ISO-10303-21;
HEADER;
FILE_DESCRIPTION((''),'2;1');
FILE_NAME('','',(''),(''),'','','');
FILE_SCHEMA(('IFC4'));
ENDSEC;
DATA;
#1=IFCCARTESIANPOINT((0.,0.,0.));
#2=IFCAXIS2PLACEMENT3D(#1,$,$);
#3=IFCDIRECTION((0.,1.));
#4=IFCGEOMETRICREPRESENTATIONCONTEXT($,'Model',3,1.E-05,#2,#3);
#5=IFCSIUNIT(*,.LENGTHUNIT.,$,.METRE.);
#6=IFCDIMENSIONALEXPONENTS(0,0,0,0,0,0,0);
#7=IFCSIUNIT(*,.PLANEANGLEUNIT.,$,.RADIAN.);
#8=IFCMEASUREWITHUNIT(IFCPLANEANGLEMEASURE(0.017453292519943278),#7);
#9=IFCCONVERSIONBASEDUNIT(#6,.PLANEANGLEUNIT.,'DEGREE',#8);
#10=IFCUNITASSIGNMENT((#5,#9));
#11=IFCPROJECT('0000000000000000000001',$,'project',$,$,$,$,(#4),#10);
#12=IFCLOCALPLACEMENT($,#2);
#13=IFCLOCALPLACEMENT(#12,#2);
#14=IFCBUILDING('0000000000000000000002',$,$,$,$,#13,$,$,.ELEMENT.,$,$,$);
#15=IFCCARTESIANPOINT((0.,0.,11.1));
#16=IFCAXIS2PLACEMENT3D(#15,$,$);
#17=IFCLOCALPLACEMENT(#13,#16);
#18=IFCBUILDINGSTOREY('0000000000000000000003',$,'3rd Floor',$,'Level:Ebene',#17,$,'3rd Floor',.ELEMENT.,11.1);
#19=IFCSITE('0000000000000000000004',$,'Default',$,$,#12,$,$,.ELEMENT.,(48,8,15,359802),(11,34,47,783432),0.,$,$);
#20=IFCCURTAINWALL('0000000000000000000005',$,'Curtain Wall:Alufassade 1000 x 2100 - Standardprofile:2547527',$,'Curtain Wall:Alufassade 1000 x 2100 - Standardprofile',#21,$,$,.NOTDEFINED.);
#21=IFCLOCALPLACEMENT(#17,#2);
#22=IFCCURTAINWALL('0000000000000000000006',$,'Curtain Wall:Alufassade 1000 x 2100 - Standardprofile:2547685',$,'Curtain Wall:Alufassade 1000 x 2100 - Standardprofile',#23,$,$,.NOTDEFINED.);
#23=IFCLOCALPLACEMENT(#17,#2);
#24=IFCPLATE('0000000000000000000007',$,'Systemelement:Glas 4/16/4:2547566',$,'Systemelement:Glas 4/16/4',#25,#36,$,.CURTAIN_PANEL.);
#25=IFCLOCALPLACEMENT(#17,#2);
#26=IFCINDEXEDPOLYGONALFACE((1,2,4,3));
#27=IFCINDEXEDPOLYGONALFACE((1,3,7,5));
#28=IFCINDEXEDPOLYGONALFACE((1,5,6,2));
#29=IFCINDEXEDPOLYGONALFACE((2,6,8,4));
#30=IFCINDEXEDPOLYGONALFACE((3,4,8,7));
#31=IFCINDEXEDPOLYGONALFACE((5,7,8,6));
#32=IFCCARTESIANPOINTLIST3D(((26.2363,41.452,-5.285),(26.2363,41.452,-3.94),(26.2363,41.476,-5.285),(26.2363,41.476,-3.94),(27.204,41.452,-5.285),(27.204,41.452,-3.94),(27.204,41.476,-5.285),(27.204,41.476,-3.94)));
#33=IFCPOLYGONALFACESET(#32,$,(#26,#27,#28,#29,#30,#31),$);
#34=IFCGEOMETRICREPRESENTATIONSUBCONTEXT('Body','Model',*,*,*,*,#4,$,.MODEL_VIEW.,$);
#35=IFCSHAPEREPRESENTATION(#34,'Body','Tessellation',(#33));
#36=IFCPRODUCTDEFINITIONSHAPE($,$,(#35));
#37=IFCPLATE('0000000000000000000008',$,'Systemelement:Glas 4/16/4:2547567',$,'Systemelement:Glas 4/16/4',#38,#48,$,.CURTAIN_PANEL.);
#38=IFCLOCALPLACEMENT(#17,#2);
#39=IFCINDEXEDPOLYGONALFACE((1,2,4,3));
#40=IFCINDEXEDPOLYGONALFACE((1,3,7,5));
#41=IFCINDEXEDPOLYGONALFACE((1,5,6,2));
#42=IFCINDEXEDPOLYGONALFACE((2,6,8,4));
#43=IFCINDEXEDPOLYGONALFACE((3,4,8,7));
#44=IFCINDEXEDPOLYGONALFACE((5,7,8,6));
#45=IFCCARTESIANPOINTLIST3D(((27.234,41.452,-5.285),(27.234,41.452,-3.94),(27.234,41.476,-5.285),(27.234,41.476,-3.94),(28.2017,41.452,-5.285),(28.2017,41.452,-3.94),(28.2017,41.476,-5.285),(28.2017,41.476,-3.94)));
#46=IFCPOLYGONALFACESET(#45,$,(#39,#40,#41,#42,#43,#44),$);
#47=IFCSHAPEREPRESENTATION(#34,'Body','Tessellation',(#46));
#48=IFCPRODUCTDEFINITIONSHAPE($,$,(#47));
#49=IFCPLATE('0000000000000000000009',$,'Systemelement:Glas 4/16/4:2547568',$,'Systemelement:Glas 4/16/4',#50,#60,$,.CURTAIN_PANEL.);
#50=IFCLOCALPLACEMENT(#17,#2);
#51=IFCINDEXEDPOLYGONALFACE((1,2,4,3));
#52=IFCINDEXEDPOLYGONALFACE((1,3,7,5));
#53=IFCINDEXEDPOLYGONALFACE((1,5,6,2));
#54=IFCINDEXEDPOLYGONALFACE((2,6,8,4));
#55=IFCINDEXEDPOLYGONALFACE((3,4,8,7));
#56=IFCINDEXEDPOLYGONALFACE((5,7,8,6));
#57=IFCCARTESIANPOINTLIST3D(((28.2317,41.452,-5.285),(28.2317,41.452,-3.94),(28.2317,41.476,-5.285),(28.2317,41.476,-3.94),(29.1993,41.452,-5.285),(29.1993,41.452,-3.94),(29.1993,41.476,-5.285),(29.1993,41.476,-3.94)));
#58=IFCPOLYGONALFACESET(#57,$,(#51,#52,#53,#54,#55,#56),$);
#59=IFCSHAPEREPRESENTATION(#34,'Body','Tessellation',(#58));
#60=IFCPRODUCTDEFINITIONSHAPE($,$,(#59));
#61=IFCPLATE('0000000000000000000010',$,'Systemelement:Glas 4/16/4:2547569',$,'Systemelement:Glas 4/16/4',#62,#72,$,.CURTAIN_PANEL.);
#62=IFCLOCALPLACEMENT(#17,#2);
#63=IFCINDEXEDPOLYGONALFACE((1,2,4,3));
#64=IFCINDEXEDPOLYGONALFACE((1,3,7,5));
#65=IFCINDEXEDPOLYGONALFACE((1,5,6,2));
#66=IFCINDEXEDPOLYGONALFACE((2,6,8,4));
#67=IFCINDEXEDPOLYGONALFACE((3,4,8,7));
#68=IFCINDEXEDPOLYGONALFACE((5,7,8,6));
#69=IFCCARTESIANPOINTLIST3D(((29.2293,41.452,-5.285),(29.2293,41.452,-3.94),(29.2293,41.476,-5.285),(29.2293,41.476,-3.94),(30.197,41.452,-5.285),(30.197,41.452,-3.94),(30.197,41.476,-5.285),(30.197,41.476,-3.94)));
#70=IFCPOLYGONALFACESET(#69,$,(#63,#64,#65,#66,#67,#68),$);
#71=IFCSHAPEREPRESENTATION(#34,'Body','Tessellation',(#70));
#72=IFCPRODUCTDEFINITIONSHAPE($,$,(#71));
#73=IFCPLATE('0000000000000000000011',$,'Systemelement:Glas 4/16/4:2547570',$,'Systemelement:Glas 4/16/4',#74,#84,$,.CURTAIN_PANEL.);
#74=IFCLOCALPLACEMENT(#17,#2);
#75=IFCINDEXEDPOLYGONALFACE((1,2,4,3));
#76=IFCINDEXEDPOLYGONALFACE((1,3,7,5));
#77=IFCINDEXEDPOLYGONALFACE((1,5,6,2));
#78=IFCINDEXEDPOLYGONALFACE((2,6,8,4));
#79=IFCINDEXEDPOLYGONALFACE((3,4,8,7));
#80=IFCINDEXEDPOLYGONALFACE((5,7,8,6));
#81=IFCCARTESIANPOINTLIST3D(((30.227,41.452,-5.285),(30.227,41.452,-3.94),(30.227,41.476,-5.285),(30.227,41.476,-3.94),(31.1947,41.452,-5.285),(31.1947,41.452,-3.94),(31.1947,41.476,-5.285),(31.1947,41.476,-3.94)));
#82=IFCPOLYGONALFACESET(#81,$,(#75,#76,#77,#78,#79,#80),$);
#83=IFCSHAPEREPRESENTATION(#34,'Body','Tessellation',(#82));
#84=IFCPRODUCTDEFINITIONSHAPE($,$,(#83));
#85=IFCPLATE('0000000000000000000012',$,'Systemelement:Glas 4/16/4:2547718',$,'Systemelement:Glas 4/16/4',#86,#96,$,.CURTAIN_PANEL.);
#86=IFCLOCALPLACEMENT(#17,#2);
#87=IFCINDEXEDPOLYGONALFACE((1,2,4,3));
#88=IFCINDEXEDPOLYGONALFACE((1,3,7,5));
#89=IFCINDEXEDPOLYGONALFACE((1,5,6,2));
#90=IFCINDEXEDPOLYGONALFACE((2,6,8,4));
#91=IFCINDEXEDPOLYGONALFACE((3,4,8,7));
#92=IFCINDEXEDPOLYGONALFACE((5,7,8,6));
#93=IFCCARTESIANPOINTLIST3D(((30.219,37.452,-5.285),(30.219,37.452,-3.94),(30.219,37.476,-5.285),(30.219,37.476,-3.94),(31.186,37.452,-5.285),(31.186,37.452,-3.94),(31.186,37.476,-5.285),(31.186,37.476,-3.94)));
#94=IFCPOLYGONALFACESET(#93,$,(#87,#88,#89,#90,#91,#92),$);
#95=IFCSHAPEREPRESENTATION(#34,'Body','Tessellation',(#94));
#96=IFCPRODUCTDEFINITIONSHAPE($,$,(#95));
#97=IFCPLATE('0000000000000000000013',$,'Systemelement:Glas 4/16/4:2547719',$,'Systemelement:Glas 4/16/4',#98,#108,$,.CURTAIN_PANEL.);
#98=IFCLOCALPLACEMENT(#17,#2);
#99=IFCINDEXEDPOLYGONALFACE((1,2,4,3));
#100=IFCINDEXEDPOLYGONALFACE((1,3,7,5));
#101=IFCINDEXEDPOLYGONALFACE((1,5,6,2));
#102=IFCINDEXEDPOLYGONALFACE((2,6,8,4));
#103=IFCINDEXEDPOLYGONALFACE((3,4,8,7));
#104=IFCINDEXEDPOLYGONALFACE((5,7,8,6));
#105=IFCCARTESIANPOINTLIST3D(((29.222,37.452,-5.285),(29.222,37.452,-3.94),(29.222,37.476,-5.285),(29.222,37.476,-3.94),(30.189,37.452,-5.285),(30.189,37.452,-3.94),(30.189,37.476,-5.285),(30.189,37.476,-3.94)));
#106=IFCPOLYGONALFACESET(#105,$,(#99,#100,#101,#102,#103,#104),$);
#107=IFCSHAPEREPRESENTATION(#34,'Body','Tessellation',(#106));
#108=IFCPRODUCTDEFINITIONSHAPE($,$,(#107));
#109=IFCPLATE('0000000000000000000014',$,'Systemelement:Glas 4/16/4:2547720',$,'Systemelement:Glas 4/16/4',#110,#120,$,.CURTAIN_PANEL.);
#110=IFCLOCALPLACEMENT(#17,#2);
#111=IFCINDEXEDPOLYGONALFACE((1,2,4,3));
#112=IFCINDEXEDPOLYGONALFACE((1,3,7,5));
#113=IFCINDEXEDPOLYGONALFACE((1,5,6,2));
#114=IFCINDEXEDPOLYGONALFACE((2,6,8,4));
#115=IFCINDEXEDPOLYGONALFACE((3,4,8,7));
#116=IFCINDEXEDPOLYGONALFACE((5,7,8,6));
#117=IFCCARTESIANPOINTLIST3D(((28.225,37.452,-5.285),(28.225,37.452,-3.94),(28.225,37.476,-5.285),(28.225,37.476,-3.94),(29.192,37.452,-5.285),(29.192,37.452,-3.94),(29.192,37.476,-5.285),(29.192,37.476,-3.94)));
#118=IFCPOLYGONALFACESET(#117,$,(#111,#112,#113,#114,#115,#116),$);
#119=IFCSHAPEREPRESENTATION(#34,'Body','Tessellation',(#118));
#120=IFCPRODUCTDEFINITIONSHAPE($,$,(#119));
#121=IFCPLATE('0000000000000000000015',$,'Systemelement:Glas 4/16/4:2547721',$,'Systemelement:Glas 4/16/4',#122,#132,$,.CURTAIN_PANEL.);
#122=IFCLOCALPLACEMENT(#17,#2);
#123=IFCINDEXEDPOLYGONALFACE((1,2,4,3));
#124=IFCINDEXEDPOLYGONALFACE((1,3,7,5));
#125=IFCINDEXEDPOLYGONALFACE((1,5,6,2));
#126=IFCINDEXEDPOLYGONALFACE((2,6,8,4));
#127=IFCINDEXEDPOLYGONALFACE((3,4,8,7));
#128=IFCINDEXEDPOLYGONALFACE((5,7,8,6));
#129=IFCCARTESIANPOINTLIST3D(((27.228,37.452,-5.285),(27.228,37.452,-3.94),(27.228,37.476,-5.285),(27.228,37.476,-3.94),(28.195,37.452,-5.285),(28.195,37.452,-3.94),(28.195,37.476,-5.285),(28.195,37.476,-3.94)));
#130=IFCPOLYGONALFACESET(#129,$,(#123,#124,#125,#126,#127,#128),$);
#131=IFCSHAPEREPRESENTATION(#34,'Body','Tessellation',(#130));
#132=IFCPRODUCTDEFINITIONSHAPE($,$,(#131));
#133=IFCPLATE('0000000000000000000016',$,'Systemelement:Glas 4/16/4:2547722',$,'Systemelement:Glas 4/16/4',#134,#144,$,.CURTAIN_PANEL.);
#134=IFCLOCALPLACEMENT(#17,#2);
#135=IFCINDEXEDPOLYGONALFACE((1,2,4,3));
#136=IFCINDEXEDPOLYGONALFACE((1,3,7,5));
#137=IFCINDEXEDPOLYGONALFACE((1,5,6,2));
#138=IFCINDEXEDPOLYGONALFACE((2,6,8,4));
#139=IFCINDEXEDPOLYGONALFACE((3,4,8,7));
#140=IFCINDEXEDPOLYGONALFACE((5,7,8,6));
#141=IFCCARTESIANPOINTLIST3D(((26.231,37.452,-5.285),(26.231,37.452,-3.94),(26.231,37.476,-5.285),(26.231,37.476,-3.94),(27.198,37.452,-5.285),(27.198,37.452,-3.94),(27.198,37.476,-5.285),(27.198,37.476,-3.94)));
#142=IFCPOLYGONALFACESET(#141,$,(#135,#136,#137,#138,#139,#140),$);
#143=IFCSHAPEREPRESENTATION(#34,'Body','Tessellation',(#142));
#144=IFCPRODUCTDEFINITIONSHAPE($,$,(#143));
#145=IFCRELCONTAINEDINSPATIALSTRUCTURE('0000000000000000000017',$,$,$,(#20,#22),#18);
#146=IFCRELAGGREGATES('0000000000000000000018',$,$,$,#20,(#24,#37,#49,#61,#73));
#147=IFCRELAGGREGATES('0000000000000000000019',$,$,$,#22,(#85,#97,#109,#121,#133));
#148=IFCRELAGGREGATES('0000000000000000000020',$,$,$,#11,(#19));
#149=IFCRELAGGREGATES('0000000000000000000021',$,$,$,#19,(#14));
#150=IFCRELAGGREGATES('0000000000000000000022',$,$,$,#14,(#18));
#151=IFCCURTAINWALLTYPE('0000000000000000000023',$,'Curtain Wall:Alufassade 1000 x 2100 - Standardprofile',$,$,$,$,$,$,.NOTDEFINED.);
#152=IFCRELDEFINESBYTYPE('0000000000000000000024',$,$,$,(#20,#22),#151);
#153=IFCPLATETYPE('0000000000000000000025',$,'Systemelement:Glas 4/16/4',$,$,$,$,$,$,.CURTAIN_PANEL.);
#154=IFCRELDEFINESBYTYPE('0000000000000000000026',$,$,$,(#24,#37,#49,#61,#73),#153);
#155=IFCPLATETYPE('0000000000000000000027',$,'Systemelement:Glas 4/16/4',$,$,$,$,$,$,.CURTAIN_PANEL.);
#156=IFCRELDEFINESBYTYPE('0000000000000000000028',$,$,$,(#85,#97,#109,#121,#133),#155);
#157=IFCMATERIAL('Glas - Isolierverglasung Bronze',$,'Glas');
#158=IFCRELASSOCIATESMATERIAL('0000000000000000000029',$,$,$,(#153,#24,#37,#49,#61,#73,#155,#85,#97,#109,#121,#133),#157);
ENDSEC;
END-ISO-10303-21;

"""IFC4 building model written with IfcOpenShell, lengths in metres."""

from ifc_helpers import new_model, entity, si_unit, converted_unit, direction, frame, origin, place, context, subcontext, project, spatial, indexed_curve, outline, extrude, source, transform, mapped, material, type_object, type_shapes, element, aggregate, save


model = new_model("IFC4")

# Units and contexts
model_context = context("Model", 3, precision=1e-05, world=origin(), true_north=direction((0.0, 1.0)))
body_context = subcontext(model_context, "Body", "Model", "MODEL_VIEW")
ifc_project = project(units=[si_unit("LENGTHUNIT", "METRE"), converted_unit("PLANEANGLEUNIT", "DEGREE", entity("IfcPlaneAngleMeasure", 0.017453292519943278), si_unit("PLANEANGLEUNIT", "RADIAN"), dimensions=[0, 0, 0, 0, 0, 0, 0])], contexts=[model_context])

# Site, building, storey
site_placement = place(None, origin())
site = spatial("IfcSite", under=ifc_project, at=site_placement, Name="Default", CompositionType="ELEMENT", RefLatitude=(48, 8, 15, 359802), RefLongitude=(11, 34, 47, 783432), RefElevation=0.0)
building_placement = place(site_placement, origin())
building = spatial("IfcBuilding", under=site, at=building_placement, CompositionType="ELEMENT")
storey_placement = place(building_placement, frame((0.0, 0.0, 11.1)))
storey = spatial("IfcBuildingStorey", under=building, at=storey_placement, Name="3rd Floor", ObjectType="Level:Ebene", LongName="3rd Floor", CompositionType="ELEMENT", Elevation=11.1)

# Curtain walls
curtain_wall_type = type_object("IfcCurtainWallType", Name="Curtain Wall:Alufassade 1000 x 2100 - Standardprofile", PredefinedType="NOTDEFINED")
curtain_wall_1_placement = place(storey_placement, frame((0.0, 0.0, -11.1)))
curtain_wall_1 = element("IfcCurtainWall", 1, at=curtain_wall_1_placement, inside=storey, type_object=curtain_wall_type, Name="Curtain Wall:Alufassade 1000 x 2100 - Standardprofile:2547527", ObjectType="Curtain Wall:Alufassade 1000 x 2100 - Standardprofile", PredefinedType="NOTDEFINED")
curtain_wall_2_placement = place(storey_placement, frame((0.0, 0.0, -11.1)))
curtain_wall_2 = element("IfcCurtainWall", 2, at=curtain_wall_2_placement, inside=storey, type_object=curtain_wall_type, Name="Curtain Wall:Alufassade 1000 x 2100 - Standardprofile:2547685", ObjectType="Curtain Wall:Alufassade 1000 x 2100 - Standardprofile", PredefinedType="NOTDEFINED")

# Plates
ifc_material_1 = material(Name="Glas - Isolierverglasung Bronze", Category="Glas")
plate_type_1 = type_object("IfcPlateType", Name="Systemelement:Glas 4/16/4", PredefinedType="CURTAIN_PANEL", material=ifc_material_1)
shared_shape_1 = source(origin(), body_context, "Body", "SweptSolid", [
    extrude(outline(indexed_curve([(-0.012, -0.4838), (0.012, -0.4838), (0.012, 0.4838), (-0.012, 0.4838), (-0.012, -0.4838)], self_intersect=False)), frame((0.0, 0.0, 0.0), z_axis=(0.0, 0.0, 1.0), x_axis=(0.0, 1.0, 0.0)), (0.0, 0.0, 1.0), 1.345),
])
type_shapes(plate_type_1, [shared_shape_1])
plate_1_placement = place(curtain_wall_1_placement, frame((26.7202, 41.464, 5.815)))
plate_1 = element("IfcPlate", 3, at=plate_1_placement, type_object=plate_type_1, material=ifc_material_1, Name="Systemelement:Glas 4/16/4:2547566", ObjectType="Systemelement:Glas 4/16/4", PredefinedType="CURTAIN_PANEL", context=body_context, shape_type="MappedRepresentation", body=[
    mapped(shared_shape_1, transform((0.0, 0.0, 0.0), scale=1.0)),
])
plate_2_placement = place(curtain_wall_1_placement, frame((27.7178, 41.464, 5.815)))
plate_2 = element("IfcPlate", 4, at=plate_2_placement, type_object=plate_type_1, material=ifc_material_1, Name="Systemelement:Glas 4/16/4:2547567", ObjectType="Systemelement:Glas 4/16/4", PredefinedType="CURTAIN_PANEL", context=body_context, shape_type="MappedRepresentation", body=[
    mapped(shared_shape_1, transform((0.0, 0.0, 0.0), scale=1.0)),
])
plate_3_placement = place(curtain_wall_1_placement, frame((28.7155, 41.464, 5.815)))
plate_3 = element("IfcPlate", 5, at=plate_3_placement, type_object=plate_type_1, material=ifc_material_1, Name="Systemelement:Glas 4/16/4:2547568", ObjectType="Systemelement:Glas 4/16/4", PredefinedType="CURTAIN_PANEL", context=body_context, shape_type="MappedRepresentation", body=[
    mapped(shared_shape_1, transform((0.0, 0.0, 0.0), scale=1.0)),
])
plate_4_placement = place(curtain_wall_1_placement, frame((29.7132, 41.464, 5.815)))
plate_4 = element("IfcPlate", 6, at=plate_4_placement, type_object=plate_type_1, material=ifc_material_1, Name="Systemelement:Glas 4/16/4:2547569", ObjectType="Systemelement:Glas 4/16/4", PredefinedType="CURTAIN_PANEL", context=body_context, shape_type="MappedRepresentation", body=[
    mapped(shared_shape_1, transform((0.0, 0.0, 0.0), scale=1.0)),
])
plate_5_placement = place(curtain_wall_1_placement, frame((30.7108, 41.464, 5.815)))
plate_5 = element("IfcPlate", 7, at=plate_5_placement, type_object=plate_type_1, material=ifc_material_1, Name="Systemelement:Glas 4/16/4:2547570", ObjectType="Systemelement:Glas 4/16/4", PredefinedType="CURTAIN_PANEL", context=body_context, shape_type="MappedRepresentation", body=[
    mapped(shared_shape_1, transform((0.0, 0.0, 0.0), scale=1.0)),
])
aggregate(curtain_wall_1, [plate_1, plate_2, plate_3, plate_4, plate_5])
plate_type_2 = type_object("IfcPlateType", Name="Systemelement:Glas 4/16/4", PredefinedType="CURTAIN_PANEL", material=ifc_material_1)
shared_shape_2 = source(origin(), body_context, "Body", "SweptSolid", [
    extrude(outline(indexed_curve([(-0.012, -0.4835), (0.012, -0.4835), (0.012, 0.4835), (-0.012, 0.4835), (-0.012, -0.4835)], self_intersect=False)), frame((0.0, 0.0, 0.0), z_axis=(0.0, 0.0, 1.0), x_axis=(0.0, 1.0, 0.0)), (0.0, 0.0, 1.0), 1.345),
])
type_shapes(plate_type_2, [shared_shape_2])
plate_6_placement = place(curtain_wall_2_placement, frame((30.7025, 37.464, 5.815), z_axis=(0.0, 0.0, 1.0), x_axis=(-1.0, 0.0, 0.0)))
plate_6 = element("IfcPlate", 8, at=plate_6_placement, type_object=plate_type_2, material=ifc_material_1, Name="Systemelement:Glas 4/16/4:2547718", ObjectType="Systemelement:Glas 4/16/4", PredefinedType="CURTAIN_PANEL", context=body_context, shape_type="MappedRepresentation", body=[
    mapped(shared_shape_2, transform((0.0, 0.0, 0.0), scale=1.0)),
])
plate_7_placement = place(curtain_wall_2_placement, frame((29.7055, 37.464, 5.815), z_axis=(0.0, 0.0, 1.0), x_axis=(-1.0, 0.0, 0.0)))
plate_7 = element("IfcPlate", 9, at=plate_7_placement, type_object=plate_type_2, material=ifc_material_1, Name="Systemelement:Glas 4/16/4:2547719", ObjectType="Systemelement:Glas 4/16/4", PredefinedType="CURTAIN_PANEL", context=body_context, shape_type="MappedRepresentation", body=[
    mapped(shared_shape_2, transform((0.0, 0.0, 0.0), scale=1.0)),
])
plate_8_placement = place(curtain_wall_2_placement, frame((28.7085, 37.464, 5.815), z_axis=(0.0, 0.0, 1.0), x_axis=(-1.0, 0.0, 0.0)))
plate_8 = element("IfcPlate", 10, at=plate_8_placement, type_object=plate_type_2, material=ifc_material_1, Name="Systemelement:Glas 4/16/4:2547720", ObjectType="Systemelement:Glas 4/16/4", PredefinedType="CURTAIN_PANEL", context=body_context, shape_type="MappedRepresentation", body=[
    mapped(shared_shape_2, transform((0.0, 0.0, 0.0), scale=1.0)),
])
plate_9_placement = place(curtain_wall_2_placement, frame((27.7115, 37.464, 5.815), z_axis=(0.0, 0.0, 1.0), x_axis=(-1.0, 0.0, 0.0)))
plate_9 = element("IfcPlate", 11, at=plate_9_placement, type_object=plate_type_2, material=ifc_material_1, Name="Systemelement:Glas 4/16/4:2547721", ObjectType="Systemelement:Glas 4/16/4", PredefinedType="CURTAIN_PANEL", context=body_context, shape_type="MappedRepresentation", body=[
    mapped(shared_shape_2, transform((0.0, 0.0, 0.0), scale=1.0)),
])
plate_10_placement = place(curtain_wall_2_placement, frame((26.7145, 37.464, 5.815), z_axis=(0.0, 0.0, 1.0), x_axis=(-1.0, 0.0, 0.0)))
plate_10 = element("IfcPlate", 12, at=plate_10_placement, type_object=plate_type_2, material=ifc_material_1, Name="Systemelement:Glas 4/16/4:2547722", ObjectType="Systemelement:Glas 4/16/4", PredefinedType="CURTAIN_PANEL", context=body_context, shape_type="MappedRepresentation", body=[
    mapped(shared_shape_2, transform((0.0, 0.0, 0.0), scale=1.0)),
])
aggregate(curtain_wall_2, [plate_6, plate_7, plate_8, plate_9, plate_10])

save(model, "model.ifc")
